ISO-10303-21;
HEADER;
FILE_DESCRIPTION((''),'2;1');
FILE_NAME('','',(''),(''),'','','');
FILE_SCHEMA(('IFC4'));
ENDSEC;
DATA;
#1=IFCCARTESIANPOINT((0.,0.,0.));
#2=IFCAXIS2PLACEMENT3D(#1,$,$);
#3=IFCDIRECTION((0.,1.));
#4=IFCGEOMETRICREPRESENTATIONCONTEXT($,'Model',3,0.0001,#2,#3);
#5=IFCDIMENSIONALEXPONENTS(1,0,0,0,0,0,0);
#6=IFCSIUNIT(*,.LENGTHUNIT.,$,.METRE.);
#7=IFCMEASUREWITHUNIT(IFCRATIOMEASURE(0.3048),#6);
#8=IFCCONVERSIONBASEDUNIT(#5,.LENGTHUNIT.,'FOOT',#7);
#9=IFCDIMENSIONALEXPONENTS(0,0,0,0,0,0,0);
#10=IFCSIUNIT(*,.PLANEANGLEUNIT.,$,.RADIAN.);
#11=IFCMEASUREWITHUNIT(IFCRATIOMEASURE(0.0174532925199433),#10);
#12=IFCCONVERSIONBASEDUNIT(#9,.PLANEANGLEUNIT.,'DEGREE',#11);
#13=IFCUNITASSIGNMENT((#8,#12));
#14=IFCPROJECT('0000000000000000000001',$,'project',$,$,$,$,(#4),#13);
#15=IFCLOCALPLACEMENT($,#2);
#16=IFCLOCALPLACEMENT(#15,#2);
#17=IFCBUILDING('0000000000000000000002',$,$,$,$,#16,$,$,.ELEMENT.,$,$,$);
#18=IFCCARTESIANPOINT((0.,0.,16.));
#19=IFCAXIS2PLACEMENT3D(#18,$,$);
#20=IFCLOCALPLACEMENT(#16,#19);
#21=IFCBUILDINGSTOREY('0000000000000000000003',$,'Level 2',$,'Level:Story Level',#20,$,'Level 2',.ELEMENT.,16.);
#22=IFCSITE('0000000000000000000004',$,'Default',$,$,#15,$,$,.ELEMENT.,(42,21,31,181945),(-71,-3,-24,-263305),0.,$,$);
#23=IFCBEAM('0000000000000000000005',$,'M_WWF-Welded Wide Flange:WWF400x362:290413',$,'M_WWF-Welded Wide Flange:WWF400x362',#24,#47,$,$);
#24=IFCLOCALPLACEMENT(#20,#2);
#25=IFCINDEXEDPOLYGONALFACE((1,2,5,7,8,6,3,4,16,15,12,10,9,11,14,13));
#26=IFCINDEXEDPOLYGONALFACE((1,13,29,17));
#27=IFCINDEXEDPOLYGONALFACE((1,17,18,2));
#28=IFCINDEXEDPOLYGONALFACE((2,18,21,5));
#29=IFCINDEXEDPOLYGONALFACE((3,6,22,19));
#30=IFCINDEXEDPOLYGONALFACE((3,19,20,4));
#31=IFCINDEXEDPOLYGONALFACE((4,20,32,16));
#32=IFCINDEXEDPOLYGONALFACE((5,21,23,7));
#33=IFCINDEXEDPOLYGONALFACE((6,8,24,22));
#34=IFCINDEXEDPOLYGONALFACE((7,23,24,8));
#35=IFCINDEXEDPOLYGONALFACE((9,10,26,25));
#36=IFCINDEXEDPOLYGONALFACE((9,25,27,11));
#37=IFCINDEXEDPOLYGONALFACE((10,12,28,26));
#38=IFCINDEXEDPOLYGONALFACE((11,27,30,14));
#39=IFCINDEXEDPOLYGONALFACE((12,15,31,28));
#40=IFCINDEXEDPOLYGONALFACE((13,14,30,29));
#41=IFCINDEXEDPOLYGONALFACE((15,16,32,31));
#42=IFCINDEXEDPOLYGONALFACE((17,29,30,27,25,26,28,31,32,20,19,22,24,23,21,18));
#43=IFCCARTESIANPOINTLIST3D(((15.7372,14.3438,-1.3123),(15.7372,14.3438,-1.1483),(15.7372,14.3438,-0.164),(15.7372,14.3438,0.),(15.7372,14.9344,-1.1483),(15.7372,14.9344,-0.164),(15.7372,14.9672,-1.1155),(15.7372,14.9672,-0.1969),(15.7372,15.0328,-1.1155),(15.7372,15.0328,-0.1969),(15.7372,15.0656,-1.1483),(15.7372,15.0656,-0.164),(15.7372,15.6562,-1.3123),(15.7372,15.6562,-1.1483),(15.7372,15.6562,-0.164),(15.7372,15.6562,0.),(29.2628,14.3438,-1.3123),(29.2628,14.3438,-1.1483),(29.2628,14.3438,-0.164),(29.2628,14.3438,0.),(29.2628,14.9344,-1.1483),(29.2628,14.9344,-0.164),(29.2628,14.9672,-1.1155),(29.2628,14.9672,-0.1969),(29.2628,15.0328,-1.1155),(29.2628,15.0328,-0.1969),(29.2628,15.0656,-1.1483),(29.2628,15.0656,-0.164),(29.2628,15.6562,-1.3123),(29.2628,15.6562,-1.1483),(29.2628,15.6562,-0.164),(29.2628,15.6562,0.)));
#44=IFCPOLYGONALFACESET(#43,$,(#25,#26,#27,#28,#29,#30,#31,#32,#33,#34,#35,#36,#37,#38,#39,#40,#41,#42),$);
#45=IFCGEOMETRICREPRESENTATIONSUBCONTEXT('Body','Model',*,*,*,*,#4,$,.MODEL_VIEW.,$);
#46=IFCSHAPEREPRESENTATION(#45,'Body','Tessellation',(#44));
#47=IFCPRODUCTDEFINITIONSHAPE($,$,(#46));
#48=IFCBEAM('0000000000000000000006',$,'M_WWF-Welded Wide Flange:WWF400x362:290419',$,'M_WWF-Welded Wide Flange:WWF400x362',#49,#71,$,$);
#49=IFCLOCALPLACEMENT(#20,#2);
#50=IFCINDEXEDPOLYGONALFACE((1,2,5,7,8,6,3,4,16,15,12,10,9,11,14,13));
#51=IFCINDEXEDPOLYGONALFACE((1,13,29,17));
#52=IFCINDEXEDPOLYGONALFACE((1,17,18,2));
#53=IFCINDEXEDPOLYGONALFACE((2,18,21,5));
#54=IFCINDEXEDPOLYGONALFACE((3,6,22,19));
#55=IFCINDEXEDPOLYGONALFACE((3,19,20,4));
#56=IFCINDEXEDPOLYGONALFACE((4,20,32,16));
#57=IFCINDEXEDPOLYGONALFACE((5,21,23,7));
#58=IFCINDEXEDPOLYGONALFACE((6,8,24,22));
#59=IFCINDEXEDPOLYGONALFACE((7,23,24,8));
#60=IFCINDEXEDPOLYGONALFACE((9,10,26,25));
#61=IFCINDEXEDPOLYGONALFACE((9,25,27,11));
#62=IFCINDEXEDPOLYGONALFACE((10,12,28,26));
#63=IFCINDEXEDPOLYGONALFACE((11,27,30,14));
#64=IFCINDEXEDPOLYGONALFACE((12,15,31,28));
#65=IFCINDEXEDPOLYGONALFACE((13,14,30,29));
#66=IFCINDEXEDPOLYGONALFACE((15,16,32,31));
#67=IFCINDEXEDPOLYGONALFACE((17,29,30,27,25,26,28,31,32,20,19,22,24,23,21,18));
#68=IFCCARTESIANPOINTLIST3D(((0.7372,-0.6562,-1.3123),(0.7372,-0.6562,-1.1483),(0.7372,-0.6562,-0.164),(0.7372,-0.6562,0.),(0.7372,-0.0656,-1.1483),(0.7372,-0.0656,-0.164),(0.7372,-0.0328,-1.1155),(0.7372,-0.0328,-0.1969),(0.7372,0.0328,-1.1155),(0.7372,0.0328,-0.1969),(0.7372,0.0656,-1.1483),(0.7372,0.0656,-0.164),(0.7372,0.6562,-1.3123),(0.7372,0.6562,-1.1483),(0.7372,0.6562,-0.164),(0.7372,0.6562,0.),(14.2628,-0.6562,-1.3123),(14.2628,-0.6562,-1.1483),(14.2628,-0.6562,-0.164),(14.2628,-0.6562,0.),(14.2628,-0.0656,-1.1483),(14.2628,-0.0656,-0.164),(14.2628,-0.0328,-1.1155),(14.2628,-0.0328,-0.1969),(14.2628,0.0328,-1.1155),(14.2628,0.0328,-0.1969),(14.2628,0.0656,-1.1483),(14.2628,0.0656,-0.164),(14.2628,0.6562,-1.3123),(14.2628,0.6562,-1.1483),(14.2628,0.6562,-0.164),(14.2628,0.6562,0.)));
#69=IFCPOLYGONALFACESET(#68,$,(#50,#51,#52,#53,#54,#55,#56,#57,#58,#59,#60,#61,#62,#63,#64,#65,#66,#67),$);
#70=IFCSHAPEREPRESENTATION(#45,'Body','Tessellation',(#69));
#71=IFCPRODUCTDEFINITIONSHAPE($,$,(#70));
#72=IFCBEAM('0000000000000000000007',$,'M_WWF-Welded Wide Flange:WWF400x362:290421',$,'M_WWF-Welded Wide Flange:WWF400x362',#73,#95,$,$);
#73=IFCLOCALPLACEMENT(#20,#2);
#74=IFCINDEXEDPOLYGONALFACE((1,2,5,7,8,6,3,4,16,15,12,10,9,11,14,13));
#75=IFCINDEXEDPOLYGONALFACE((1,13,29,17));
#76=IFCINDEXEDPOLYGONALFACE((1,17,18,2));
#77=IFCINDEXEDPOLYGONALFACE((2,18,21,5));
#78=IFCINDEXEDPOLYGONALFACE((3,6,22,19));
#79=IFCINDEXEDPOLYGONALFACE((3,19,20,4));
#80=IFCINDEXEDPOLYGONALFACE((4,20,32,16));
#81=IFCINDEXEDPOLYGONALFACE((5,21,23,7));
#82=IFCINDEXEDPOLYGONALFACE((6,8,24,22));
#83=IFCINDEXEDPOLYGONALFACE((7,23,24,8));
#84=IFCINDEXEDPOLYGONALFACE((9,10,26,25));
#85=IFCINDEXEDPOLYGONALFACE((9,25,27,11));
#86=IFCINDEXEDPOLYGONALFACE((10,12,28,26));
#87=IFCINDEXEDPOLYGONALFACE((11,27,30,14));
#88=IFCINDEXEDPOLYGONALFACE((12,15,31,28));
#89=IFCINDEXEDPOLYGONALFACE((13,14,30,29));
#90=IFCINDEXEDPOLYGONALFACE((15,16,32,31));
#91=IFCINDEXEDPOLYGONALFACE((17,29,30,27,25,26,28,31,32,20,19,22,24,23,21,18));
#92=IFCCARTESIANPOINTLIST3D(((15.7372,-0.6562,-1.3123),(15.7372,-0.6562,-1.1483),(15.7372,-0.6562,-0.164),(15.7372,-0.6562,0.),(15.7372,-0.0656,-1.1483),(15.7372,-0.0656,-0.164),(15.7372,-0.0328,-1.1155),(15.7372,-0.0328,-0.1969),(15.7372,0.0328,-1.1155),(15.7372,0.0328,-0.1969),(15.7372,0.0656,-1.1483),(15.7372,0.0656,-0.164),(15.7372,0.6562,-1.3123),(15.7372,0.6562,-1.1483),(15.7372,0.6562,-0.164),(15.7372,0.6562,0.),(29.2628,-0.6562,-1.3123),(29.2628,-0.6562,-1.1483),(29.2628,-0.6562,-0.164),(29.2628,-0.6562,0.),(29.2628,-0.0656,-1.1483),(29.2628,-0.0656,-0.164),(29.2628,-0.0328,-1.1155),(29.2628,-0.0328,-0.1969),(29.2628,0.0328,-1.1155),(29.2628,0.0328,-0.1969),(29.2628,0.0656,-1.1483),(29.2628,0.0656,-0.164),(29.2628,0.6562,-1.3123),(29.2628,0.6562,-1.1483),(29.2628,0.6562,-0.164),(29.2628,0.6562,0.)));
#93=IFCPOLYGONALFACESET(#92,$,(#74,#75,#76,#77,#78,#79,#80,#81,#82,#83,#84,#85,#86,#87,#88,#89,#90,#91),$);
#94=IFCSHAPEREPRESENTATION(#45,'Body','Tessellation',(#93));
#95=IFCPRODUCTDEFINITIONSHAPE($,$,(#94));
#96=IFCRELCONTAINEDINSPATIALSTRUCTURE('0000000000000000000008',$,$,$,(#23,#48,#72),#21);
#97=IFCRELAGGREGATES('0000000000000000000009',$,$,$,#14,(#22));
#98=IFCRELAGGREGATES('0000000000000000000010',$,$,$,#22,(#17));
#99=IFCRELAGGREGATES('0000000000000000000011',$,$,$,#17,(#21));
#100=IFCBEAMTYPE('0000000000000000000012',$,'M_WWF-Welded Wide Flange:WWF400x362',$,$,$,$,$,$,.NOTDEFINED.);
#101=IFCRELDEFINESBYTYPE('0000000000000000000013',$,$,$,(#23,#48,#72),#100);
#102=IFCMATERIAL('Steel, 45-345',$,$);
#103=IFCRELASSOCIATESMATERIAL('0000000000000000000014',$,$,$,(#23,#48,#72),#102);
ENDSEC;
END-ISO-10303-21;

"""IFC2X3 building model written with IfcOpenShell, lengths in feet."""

from ifc_helpers import new_model, entity, si_unit, converted_unit, direction, frame, origin, place, context, subcontext, project, spatial, polyline, outline, extrude, material, type_object, element, save


model = new_model("IFC2X3")

# Units and contexts
model_context = context("Model", 3, precision=0.0001, world=origin(), true_north=direction((0.0, 1.0)))
body_context = subcontext(model_context, "Body", "Model", "MODEL_VIEW")
ifc_project = project(units=[converted_unit("LENGTHUNIT", "FOOT", entity("IfcRatioMeasure", 0.3048), si_unit("LENGTHUNIT", "METRE"), dimensions=[1, 0, 0, 0, 0, 0, 0]), converted_unit("PLANEANGLEUNIT", "DEGREE", entity("IfcRatioMeasure", 0.0174532925199433), si_unit("PLANEANGLEUNIT", "RADIAN"), dimensions=[0, 0, 0, 0, 0, 0, 0])], contexts=[model_context])

# Site, building, storey
site_placement = place(None, origin())
site = spatial("IfcSite", under=ifc_project, at=site_placement, Name="Default", CompositionType="ELEMENT", RefLatitude=(42, 21, 31, 181945), RefLongitude=(-71, -3, -24, -263305), RefElevation=0.0)
building_placement = place(site_placement, origin())
building = spatial("IfcBuilding", under=site, at=building_placement, CompositionType="ELEMENT")
storey_placement = place(building_placement, frame((0.0, 0.0, 16.0)))
storey = spatial("IfcBuildingStorey", under=building, at=storey_placement, Name="Level 2", ObjectType="Level:Story Level", LongName="Level 2", CompositionType="ELEMENT", Elevation=16.0)

# Shared definitions
ifc_material = material(Name="Steel, 45-345")

# Beams
beam_type = type_object("IfcBeamType", Name="M_WWF-Welded Wide Flange:WWF400x362", PredefinedType="NOTDEFINED")
beam_1_placement = place(storey_placement, frame((15.0, 15.0, 0.0)))
element("IfcBeam", 1, at=beam_1_placement, inside=storey, type_object=beam_type, material=ifc_material, Name="M_WWF-Welded Wide Flange:WWF400x362:290413", ObjectType="M_WWF-Welded Wide Flange:WWF400x362", context=body_context, shape_type="SweptSolid", body=[
    extrude(outline(polyline([(-0.6562, -0.6562), (-0.4921, -0.6562), (-0.4921, -0.0656), (-0.4593, -0.0328), (0.4593, -0.0328), (0.4921, -0.0656), (0.4921, -0.6562), (0.6562, -0.6562), (0.6562, 0.6562), (0.4921, 0.6562), (0.4921, 0.0656), (0.4593, 0.0328), (-0.4593, 0.0328), (-0.4921, 0.0656), (-0.4921, 0.6562), (-0.6562, 0.6562), (-0.6562, -0.6562)])), frame((0.7372, 0.0, -0.6562), z_axis=(1.0, 0.0, 0.0), x_axis=(0.0, 0.0, -1.0)), (0.0, 0.0, 1.0), 13.5256),
])
beam_2_placement = place(storey_placement, origin())
element("IfcBeam", 2, at=beam_2_placement, inside=storey, type_object=beam_type, material=ifc_material, Name="M_WWF-Welded Wide Flange:WWF400x362:290419", ObjectType="M_WWF-Welded Wide Flange:WWF400x362", context=body_context, shape_type="SweptSolid", body=[
    extrude(outline(polyline([(-0.6562, -0.6562), (-0.4921, -0.6562), (-0.4921, -0.0656), (-0.4593, -0.0328), (0.4593, -0.0328), (0.4921, -0.0656), (0.4921, -0.6562), (0.6562, -0.6562), (0.6562, 0.6562), (0.4921, 0.6562), (0.4921, 0.0656), (0.4593, 0.0328), (-0.4593, 0.0328), (-0.4921, 0.0656), (-0.4921, 0.6562), (-0.6562, 0.6562), (-0.6562, -0.6562)])), frame((0.7372, 0.0, -0.6562), z_axis=(1.0, 0.0, 0.0), x_axis=(0.0, 0.0, -1.0)), (0.0, 0.0, 1.0), 13.5256),
])
beam_3_placement = place(storey_placement, frame((15.0, 0.0, 0.0)))
element("IfcBeam", 3, at=beam_3_placement, inside=storey, type_object=beam_type, material=ifc_material, Name="M_WWF-Welded Wide Flange:WWF400x362:290421", ObjectType="M_WWF-Welded Wide Flange:WWF400x362", context=body_context, shape_type="SweptSolid", body=[
    extrude(outline(polyline([(-0.6562, -0.6562), (-0.4921, -0.6562), (-0.4921, -0.0656), (-0.4593, -0.0328), (0.4593, -0.0328), (0.4921, -0.0656), (0.4921, -0.6562), (0.6562, -0.6562), (0.6562, 0.6562), (0.4921, 0.6562), (0.4921, 0.0656), (0.4593, 0.0328), (-0.4593, 0.0328), (-0.4921, 0.0656), (-0.4921, 0.6562), (-0.6562, 0.6562), (-0.6562, -0.6562)])), frame((0.7372, 0.0, -0.6562), z_axis=(1.0, 0.0, 0.0), x_axis=(0.0, 0.0, -1.0)), (0.0, 0.0, 1.0), 13.5256),
])

save(model, "model.ifc")
